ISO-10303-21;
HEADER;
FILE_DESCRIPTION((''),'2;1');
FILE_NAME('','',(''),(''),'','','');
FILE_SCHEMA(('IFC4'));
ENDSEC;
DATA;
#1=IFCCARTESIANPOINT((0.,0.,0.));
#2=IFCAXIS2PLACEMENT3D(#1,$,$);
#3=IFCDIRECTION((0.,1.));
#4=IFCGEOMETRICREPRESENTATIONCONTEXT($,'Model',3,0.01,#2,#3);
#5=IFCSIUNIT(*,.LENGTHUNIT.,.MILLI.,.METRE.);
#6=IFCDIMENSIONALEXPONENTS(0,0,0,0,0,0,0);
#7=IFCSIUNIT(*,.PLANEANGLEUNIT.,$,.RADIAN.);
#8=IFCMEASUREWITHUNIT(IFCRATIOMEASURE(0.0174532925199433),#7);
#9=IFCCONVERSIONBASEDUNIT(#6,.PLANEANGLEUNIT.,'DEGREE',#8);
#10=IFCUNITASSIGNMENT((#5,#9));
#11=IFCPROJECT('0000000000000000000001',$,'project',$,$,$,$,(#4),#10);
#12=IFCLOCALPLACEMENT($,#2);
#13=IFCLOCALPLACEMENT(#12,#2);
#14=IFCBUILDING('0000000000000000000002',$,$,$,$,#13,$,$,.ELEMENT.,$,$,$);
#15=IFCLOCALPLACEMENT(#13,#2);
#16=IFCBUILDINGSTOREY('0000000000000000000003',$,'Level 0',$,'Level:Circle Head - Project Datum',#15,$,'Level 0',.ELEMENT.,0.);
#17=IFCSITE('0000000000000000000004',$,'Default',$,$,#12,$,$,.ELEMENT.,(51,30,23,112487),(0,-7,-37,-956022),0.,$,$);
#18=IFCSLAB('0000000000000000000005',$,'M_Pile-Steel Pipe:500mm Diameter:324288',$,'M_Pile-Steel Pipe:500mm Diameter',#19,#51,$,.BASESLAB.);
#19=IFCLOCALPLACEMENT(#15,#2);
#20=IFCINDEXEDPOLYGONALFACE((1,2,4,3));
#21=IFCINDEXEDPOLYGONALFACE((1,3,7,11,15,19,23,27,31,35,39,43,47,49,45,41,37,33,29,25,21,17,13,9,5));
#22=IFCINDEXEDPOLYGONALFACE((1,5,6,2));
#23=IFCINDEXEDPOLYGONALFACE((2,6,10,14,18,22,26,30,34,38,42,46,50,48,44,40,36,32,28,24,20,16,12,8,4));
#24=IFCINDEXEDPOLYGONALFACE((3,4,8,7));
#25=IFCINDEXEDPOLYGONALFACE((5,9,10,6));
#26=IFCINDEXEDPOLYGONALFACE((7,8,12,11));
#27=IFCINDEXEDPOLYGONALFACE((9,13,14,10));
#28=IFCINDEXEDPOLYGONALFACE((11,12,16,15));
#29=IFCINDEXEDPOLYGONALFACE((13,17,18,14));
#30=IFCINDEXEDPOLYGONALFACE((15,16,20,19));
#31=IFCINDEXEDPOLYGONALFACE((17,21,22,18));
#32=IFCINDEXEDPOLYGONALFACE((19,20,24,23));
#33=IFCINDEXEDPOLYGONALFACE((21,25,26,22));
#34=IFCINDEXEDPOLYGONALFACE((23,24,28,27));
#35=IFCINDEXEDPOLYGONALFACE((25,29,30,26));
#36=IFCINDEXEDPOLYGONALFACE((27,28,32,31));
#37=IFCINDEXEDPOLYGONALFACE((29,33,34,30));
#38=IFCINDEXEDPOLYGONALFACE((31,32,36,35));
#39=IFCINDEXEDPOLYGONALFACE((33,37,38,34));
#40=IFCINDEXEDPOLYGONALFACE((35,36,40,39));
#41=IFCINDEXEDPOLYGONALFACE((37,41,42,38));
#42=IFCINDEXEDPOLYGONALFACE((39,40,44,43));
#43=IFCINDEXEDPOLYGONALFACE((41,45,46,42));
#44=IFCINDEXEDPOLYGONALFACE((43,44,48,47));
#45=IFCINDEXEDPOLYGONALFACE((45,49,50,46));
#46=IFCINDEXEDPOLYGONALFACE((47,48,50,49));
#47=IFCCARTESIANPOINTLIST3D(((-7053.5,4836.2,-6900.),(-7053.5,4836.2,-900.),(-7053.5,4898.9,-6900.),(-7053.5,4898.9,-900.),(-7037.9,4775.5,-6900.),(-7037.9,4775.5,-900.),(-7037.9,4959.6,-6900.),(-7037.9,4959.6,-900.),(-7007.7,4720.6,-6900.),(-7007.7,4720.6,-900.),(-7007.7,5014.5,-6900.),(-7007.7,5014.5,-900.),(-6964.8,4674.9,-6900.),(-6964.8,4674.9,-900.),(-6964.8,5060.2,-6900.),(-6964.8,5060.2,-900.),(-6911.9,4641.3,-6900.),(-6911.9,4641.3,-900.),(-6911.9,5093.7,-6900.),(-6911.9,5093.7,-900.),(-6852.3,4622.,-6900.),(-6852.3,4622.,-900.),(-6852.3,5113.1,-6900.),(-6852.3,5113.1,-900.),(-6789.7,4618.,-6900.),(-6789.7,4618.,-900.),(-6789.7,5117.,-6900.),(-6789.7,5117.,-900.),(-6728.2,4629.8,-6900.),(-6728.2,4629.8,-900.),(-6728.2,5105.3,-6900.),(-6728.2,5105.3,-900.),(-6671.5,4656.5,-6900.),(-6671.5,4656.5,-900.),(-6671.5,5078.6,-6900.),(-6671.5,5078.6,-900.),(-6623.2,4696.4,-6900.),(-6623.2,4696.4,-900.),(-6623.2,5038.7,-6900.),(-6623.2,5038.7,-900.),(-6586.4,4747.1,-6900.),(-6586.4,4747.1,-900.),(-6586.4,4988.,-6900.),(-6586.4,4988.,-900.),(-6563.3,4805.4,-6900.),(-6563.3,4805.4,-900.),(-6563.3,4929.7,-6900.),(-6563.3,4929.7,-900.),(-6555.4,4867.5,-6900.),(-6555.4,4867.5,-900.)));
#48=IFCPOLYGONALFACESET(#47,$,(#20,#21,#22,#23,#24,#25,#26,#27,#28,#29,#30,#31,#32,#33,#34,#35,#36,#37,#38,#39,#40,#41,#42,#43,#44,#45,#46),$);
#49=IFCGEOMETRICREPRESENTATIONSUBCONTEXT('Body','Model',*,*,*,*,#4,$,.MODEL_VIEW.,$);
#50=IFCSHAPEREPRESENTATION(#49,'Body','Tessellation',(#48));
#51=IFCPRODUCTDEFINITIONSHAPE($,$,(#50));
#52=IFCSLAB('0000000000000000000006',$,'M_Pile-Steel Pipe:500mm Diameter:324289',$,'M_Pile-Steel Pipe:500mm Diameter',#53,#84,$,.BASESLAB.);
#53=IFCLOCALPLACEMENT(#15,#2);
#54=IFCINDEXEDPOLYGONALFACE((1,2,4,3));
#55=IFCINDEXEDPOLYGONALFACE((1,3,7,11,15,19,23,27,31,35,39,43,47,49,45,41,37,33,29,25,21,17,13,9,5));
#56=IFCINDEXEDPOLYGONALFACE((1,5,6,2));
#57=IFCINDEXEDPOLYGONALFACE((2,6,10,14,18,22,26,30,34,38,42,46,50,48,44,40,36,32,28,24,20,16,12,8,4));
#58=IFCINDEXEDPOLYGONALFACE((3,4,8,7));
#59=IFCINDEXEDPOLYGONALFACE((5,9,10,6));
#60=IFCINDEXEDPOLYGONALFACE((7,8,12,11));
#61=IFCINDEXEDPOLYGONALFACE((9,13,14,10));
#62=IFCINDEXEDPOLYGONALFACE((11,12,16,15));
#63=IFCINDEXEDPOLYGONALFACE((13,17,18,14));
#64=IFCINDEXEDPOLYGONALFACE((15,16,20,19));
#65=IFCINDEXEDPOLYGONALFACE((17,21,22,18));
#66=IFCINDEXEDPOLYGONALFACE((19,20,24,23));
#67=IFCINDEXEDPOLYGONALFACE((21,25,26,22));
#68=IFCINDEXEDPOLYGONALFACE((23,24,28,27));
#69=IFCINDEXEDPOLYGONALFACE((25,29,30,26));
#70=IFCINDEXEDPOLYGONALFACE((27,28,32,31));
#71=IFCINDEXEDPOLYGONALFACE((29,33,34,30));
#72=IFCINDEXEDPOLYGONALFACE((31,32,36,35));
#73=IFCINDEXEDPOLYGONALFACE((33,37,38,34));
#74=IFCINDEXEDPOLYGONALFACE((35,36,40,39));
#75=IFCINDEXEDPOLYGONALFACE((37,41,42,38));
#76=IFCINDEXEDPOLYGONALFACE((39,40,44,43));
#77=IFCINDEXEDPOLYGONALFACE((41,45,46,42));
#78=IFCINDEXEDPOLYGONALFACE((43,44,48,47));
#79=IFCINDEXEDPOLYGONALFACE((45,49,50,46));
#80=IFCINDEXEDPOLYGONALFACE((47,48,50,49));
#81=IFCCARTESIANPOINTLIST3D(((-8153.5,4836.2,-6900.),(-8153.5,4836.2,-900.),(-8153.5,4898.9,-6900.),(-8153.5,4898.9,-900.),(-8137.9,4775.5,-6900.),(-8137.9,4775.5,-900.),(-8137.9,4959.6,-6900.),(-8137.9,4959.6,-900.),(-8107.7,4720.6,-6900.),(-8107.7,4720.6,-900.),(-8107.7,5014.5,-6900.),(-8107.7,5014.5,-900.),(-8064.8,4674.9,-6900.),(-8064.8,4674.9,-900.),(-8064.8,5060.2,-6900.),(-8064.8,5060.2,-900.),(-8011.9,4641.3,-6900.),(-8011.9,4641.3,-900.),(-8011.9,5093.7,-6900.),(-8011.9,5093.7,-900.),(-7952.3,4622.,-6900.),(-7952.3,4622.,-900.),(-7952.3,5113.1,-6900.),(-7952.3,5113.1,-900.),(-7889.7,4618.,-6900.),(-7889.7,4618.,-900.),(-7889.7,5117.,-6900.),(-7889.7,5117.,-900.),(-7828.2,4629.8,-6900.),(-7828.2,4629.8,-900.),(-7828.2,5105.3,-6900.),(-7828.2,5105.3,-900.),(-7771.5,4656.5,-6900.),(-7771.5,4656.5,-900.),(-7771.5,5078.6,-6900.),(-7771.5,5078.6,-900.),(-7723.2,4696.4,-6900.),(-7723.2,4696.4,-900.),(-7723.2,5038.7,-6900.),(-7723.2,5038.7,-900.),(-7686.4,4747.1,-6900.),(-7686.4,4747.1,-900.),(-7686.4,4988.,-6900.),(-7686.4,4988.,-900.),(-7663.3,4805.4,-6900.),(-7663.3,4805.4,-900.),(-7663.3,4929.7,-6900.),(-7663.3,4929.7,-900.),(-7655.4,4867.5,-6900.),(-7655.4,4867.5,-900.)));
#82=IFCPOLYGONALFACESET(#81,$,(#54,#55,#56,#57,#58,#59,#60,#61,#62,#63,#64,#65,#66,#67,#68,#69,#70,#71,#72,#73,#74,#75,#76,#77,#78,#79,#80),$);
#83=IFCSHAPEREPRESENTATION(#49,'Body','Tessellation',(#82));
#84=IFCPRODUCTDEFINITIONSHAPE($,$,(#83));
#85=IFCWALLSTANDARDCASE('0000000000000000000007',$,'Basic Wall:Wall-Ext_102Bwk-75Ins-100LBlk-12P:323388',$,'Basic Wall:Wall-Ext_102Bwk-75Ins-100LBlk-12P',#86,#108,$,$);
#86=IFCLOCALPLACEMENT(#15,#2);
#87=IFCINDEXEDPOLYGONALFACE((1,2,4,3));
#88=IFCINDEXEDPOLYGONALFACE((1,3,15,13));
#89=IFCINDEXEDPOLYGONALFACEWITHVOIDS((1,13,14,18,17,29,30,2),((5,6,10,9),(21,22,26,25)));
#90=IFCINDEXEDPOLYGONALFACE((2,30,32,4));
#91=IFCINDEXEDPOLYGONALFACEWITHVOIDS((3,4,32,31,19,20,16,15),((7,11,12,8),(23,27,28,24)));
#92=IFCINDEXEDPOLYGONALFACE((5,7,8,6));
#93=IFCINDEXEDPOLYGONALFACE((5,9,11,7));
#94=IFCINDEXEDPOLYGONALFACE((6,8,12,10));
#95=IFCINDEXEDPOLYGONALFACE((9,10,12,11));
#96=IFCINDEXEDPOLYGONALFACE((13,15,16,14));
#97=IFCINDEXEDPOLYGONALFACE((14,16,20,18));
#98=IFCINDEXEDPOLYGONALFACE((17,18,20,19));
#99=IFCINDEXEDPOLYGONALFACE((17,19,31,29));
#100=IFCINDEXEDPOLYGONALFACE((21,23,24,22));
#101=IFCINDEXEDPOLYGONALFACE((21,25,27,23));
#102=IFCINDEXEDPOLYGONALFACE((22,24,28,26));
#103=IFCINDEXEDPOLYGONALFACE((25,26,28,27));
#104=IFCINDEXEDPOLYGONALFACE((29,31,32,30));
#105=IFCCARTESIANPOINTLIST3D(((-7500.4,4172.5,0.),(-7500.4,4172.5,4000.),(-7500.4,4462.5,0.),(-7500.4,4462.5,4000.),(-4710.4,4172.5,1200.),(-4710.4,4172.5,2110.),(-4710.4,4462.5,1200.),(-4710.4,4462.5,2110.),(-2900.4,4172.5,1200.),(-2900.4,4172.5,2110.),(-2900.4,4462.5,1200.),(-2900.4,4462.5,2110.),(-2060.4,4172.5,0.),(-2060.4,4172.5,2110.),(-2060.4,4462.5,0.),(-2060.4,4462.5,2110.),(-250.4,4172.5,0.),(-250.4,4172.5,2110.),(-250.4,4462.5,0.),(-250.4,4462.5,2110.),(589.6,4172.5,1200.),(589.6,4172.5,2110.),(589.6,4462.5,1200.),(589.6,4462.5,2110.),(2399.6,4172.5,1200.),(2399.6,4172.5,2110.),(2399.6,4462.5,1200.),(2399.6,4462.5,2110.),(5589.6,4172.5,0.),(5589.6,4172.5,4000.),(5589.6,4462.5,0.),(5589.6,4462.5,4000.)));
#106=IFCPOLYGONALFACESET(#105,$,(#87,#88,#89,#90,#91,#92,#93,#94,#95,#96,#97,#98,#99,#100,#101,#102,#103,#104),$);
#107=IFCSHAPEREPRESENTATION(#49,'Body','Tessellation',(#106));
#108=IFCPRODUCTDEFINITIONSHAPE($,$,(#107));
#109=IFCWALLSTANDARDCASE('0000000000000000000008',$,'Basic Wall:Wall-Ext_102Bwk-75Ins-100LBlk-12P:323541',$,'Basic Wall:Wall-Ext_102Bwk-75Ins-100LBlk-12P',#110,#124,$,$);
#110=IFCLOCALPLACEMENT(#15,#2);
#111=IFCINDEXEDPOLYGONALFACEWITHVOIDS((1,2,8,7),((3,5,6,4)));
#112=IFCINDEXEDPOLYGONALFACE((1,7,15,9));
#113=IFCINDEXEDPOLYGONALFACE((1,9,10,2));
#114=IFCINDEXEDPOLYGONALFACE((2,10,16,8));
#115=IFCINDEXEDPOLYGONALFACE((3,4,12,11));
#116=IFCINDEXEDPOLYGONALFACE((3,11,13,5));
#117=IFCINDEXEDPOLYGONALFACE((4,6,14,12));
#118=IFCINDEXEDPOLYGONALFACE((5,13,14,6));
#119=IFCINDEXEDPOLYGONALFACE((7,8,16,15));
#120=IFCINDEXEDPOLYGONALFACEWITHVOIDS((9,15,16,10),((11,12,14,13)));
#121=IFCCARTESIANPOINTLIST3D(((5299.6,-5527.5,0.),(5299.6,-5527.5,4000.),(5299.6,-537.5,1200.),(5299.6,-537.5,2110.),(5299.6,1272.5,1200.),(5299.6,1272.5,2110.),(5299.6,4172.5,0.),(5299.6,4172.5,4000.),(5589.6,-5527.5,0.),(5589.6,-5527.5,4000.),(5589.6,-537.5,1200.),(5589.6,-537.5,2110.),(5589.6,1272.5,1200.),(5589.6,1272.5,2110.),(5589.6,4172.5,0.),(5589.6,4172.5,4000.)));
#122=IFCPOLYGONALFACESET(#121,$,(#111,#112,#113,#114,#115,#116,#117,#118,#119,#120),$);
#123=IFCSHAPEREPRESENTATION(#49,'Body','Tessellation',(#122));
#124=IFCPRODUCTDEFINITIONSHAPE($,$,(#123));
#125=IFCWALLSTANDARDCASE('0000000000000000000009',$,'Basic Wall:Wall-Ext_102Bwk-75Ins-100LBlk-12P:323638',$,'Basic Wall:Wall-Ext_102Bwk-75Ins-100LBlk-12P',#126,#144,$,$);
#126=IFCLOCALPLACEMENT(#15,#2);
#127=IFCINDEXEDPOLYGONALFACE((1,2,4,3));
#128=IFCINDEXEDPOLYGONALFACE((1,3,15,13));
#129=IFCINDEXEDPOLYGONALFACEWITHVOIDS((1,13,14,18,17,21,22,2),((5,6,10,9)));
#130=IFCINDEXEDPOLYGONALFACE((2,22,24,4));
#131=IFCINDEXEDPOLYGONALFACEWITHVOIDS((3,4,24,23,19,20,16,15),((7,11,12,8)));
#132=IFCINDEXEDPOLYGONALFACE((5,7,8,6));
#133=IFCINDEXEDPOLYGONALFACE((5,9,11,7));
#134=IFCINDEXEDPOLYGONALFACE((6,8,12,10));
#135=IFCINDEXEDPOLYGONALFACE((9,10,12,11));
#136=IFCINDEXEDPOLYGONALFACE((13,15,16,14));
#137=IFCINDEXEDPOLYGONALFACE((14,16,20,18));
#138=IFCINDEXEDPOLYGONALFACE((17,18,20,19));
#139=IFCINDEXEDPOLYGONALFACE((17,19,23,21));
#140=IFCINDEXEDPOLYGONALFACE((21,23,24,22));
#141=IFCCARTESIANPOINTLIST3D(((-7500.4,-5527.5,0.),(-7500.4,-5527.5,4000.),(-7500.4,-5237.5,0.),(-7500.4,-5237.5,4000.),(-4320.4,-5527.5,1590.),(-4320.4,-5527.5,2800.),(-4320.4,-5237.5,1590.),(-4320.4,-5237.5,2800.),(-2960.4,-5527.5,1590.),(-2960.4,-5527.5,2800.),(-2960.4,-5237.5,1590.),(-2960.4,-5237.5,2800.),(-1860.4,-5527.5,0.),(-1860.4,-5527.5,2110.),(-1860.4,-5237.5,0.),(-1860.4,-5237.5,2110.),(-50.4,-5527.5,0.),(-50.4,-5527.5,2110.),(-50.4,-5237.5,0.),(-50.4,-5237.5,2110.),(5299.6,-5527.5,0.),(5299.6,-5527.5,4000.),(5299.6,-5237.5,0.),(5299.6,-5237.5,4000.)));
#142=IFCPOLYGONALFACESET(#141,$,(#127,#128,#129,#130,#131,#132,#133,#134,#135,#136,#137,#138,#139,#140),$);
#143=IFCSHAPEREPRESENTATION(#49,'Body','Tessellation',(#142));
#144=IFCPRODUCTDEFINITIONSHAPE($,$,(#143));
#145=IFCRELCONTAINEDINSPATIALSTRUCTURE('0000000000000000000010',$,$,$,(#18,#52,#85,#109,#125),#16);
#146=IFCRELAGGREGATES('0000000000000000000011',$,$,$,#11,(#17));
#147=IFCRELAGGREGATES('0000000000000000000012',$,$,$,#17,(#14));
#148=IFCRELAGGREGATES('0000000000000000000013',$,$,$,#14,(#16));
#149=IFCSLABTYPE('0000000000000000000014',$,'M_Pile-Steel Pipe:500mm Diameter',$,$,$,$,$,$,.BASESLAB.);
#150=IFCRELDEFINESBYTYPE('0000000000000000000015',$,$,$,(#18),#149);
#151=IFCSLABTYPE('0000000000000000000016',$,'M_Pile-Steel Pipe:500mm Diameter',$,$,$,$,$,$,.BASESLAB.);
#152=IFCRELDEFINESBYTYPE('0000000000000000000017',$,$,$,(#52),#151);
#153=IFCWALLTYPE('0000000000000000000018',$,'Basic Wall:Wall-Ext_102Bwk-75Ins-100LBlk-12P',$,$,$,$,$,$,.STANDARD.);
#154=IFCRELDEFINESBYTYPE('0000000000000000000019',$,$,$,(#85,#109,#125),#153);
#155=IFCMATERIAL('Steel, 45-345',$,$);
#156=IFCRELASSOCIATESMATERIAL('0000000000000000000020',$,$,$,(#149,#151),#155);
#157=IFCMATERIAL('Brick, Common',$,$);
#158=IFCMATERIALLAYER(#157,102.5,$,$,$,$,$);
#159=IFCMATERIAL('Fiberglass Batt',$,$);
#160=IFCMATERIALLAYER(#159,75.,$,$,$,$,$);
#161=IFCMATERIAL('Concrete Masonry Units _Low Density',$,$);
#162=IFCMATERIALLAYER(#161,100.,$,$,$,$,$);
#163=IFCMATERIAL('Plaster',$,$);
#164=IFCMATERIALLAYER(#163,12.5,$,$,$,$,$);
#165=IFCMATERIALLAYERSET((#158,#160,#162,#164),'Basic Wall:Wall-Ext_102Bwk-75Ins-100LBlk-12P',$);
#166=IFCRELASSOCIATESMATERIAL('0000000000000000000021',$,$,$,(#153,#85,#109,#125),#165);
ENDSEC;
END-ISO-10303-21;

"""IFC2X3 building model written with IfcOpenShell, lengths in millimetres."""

from ifc_helpers import new_model, entity, si_unit, converted_unit, direction, frame, frame_2d, origin, place, context, subcontext, project, spatial, rectangle, circle, extrude, material, layer, layer_set, layer_usage, type_object, element, save


model = new_model("IFC2X3")

# Units and contexts
model_context = context("Model", 3, precision=0.01, world=origin(), true_north=direction((0.0, 1.0)))
body_context = subcontext(model_context, "Body", "Model", "MODEL_VIEW")
ifc_project = project(units=[si_unit("LENGTHUNIT", "METRE", prefix="MILLI"), converted_unit("PLANEANGLEUNIT", "DEGREE", entity("IfcRatioMeasure", 0.0174532925199433), si_unit("PLANEANGLEUNIT", "RADIAN"), dimensions=[0, 0, 0, 0, 0, 0, 0])], contexts=[model_context])

# Site, building, storey
site_placement = place(None, origin())
site = spatial("IfcSite", under=ifc_project, at=site_placement, Name="Default", CompositionType="ELEMENT", RefLatitude=(51, 30, 23, 112487), RefLongitude=(0, -7, -37, -956022), RefElevation=0.0)
building_placement = place(site_placement, origin())
building = spatial("IfcBuilding", under=site, at=building_placement, CompositionType="ELEMENT")
storey_placement = place(building_placement, origin())
storey = spatial("IfcBuildingStorey", under=building, at=storey_placement, Name="Level 0", ObjectType="Level:Circle Head - Project Datum", LongName="Level 0", CompositionType="ELEMENT", Elevation=0.0)

# Slabs
ifc_material_1 = material(Name="Steel, 45-345")
slab_type_1 = type_object("IfcSlabType", Name="M_Pile-Steel Pipe:500mm Diameter", PredefinedType="BASESLAB", material=ifc_material_1)
slab_1_placement = place(storey_placement, origin())
element("IfcSlab", 1, at=slab_1_placement, inside=storey, type_object=slab_type_1, Name="M_Pile-Steel Pipe:500mm Diameter:324288", ObjectType="M_Pile-Steel Pipe:500mm Diameter", PredefinedType="BASESLAB", context=body_context, shape_type="SweptSolid", body=[
    extrude(circle(Radius=250.0, at=frame_2d((0.0, 0.0), x_axis=(1.0, 0.0))), frame((-6805.4, 4867.5, -6900.0)), (0.0, 0.0, 1.0), 6000.0),
])
slab_type_2 = type_object("IfcSlabType", Name="M_Pile-Steel Pipe:500mm Diameter", PredefinedType="BASESLAB", material=ifc_material_1)
slab_2_placement = place(storey_placement, origin())
element("IfcSlab", 2, at=slab_2_placement, inside=storey, type_object=slab_type_2, Name="M_Pile-Steel Pipe:500mm Diameter:324289", ObjectType="M_Pile-Steel Pipe:500mm Diameter", PredefinedType="BASESLAB", context=body_context, shape_type="SweptSolid", body=[
    extrude(circle(Radius=250.0, at=frame_2d((0.0, 0.0), x_axis=(1.0, 0.0))), frame((-7905.4, 4867.5, -6900.0)), (0.0, 0.0, 1.0), 6000.0),
])

# Wall, openings
ifc_material_2 = material(Name="Brick, Common")
ifc_layer_1 = layer(ifc_material_2, 102.5)
ifc_material_3 = material(Name="Fiberglass Batt")
ifc_layer_2 = layer(ifc_material_3, 75.0)
ifc_material_4 = material(Name="Concrete Masonry Units _Low Density")
ifc_layer_3 = layer(ifc_material_4, 100.0)
ifc_material_5 = material(Name="Plaster")
ifc_layer_4 = layer(ifc_material_5, 12.5)
ifc_layer_set_1 = layer_set([ifc_layer_1, ifc_layer_2, ifc_layer_3, ifc_layer_4], Name="Basic Wall:Wall-Ext_102Bwk-75Ins-100LBlk-12P")
ifc_layer_usage_1 = layer_usage(ifc_layer_set_1, "AXIS2", "NEGATIVE", 145.0)
wall_type = type_object("IfcWallType", Name="Basic Wall:Wall-Ext_102Bwk-75Ins-100LBlk-12P", PredefinedType="STANDARD", material=ifc_layer_set_1)
wall_1_placement = place(storey_placement, frame((-7500.4, 4317.5, 0.0)))
wall_1 = element("IfcWallStandardCase", 3, at=wall_1_placement, inside=storey, type_object=wall_type, material=ifc_layer_usage_1, Name="Basic Wall:Wall-Ext_102Bwk-75Ins-100LBlk-12P:323388", ObjectType="Basic Wall:Wall-Ext_102Bwk-75Ins-100LBlk-12P", context=body_context, shape_type="SweptSolid", body=[
    extrude(rectangle(XDim=13090.0, YDim=290.0, at=frame_2d((6545.0, 0.0), x_axis=(-1.0, 0.0))), origin(), (0.0, 0.0, 1.0), 4000.0),
])
opening_1_placement = place(wall_1_placement, frame((7250.0, 145.0, 0.0)))
element("IfcOpeningElement", 4, at=opening_1_placement, cuts=wall_1, ObjectType="Opening", context=body_context, shape_type="SweptSolid", body=[
    extrude(rectangle(XDim=2110.0, YDim=1810.0, at=frame_2d((1055.0, 905.0), x_axis=(-1.0, 0.0))), frame((0.0, 0.0, 0.0), z_axis=(0.0, -1.0, 0.0), x_axis=(0.0, 0.0, 1.0)), (0.0, 0.0, 1.0), 290.0),
])
opening_2_placement = place(wall_1_placement, frame((2790.0, -145.0, 1200.0)))
element("IfcOpeningElement", 5, at=opening_2_placement, cuts=wall_1, ObjectType="Opening", context=body_context, shape_type="SweptSolid", body=[
    extrude(rectangle(XDim=910.0, YDim=1810.0, at=frame_2d((455.0, 905.0), x_axis=(-1.0, 0.0))), frame((0.0, 0.0, 0.0), z_axis=(0.0, 1.0, 0.0), x_axis=(0.0, 0.0, 1.0)), (0.0, 0.0, 1.0), 290.0),
])
opening_3_placement = place(wall_1_placement, frame((8090.0, -145.0, 1200.0)))
element("IfcOpeningElement", 6, at=opening_3_placement, cuts=wall_1, ObjectType="Opening", context=body_context, shape_type="SweptSolid", body=[
    extrude(rectangle(XDim=910.0, YDim=1810.0, at=frame_2d((455.0, 905.0), x_axis=(-1.0, 0.0))), frame((0.0, 0.0, 0.0), z_axis=(0.0, 1.0, 0.0), x_axis=(0.0, 0.0, 1.0)), (0.0, 0.0, 1.0), 290.0),
])

# Wall, opening
ifc_layer_usage_2 = layer_usage(ifc_layer_set_1, "AXIS2", "NEGATIVE", 145.0)
wall_2_placement = place(storey_placement, frame((5444.6, 4172.5, 0.0), z_axis=(0.0, 0.0, 1.0), x_axis=(0.0, -1.0, 0.0)))
wall_2 = element("IfcWallStandardCase", 7, at=wall_2_placement, inside=storey, type_object=wall_type, material=ifc_layer_usage_2, Name="Basic Wall:Wall-Ext_102Bwk-75Ins-100LBlk-12P:323541", ObjectType="Basic Wall:Wall-Ext_102Bwk-75Ins-100LBlk-12P", context=body_context, shape_type="SweptSolid", body=[
    extrude(rectangle(XDim=9700.0, YDim=290.0, at=frame_2d((4850.0, 0.0), x_axis=(-1.0, 0.0))), origin(), (0.0, 0.0, 1.0), 4000.0),
])
opening_4_placement = place(wall_2_placement, frame((2900.0, -145.0, 1200.0)))
element("IfcOpeningElement", 8, at=opening_4_placement, cuts=wall_2, ObjectType="Opening", context=body_context, shape_type="SweptSolid", body=[
    extrude(rectangle(XDim=910.0, YDim=1810.0, at=frame_2d((455.0, 905.0), x_axis=(-1.0, 0.0))), frame((0.0, 0.0, 0.0), z_axis=(0.0, 1.0, 0.0), x_axis=(0.0, 0.0, 1.0)), (0.0, 0.0, 1.0), 290.0),
])

# Wall, openings
ifc_layer_usage_3 = layer_usage(ifc_layer_set_1, "AXIS2", "NEGATIVE", 145.0)
wall_3_placement = place(storey_placement, frame((5299.6, -5382.5, 0.0), z_axis=(0.0, 0.0, 1.0), x_axis=(-1.0, 0.0, 0.0)))
wall_3 = element("IfcWallStandardCase", 9, at=wall_3_placement, inside=storey, type_object=wall_type, material=ifc_layer_usage_3, Name="Basic Wall:Wall-Ext_102Bwk-75Ins-100LBlk-12P:323638", ObjectType="Basic Wall:Wall-Ext_102Bwk-75Ins-100LBlk-12P", context=body_context, shape_type="SweptSolid", body=[
    extrude(rectangle(XDim=12800.0, YDim=290.0, at=frame_2d((6400.0, 0.0), x_axis=(-1.0, 0.0))), origin(), (0.0, 0.0, 1.0), 4000.0),
])
opening_5_placement = place(wall_3_placement, frame((7160.0, 145.0, 0.0)))
element("IfcOpeningElement", 10, at=opening_5_placement, cuts=wall_3, ObjectType="Opening", context=body_context, shape_type="SweptSolid", body=[
    extrude(rectangle(XDim=2110.0, YDim=1810.0, at=frame_2d((1055.0, 905.0), x_axis=(-1.0, 0.0))), frame((0.0, 0.0, 0.0), z_axis=(0.0, -1.0, 0.0), x_axis=(0.0, 0.0, 1.0)), (0.0, 0.0, 1.0), 290.0),
])
opening_6_placement = place(wall_3_placement, frame((8260.0, -145.0, 1590.0)))
element("IfcOpeningElement", 11, at=opening_6_placement, cuts=wall_3, ObjectType="Opening", context=body_context, shape_type="SweptSolid", body=[
    extrude(rectangle(XDim=1210.0, YDim=1360.0, at=frame_2d((605.0, 680.0), x_axis=(-1.0, 0.0))), frame((0.0, 0.0, 0.0), z_axis=(0.0, 1.0, 0.0), x_axis=(0.0, 0.0, 1.0)), (0.0, 0.0, 1.0), 290.0),
])

save(model, "model.ifc")
